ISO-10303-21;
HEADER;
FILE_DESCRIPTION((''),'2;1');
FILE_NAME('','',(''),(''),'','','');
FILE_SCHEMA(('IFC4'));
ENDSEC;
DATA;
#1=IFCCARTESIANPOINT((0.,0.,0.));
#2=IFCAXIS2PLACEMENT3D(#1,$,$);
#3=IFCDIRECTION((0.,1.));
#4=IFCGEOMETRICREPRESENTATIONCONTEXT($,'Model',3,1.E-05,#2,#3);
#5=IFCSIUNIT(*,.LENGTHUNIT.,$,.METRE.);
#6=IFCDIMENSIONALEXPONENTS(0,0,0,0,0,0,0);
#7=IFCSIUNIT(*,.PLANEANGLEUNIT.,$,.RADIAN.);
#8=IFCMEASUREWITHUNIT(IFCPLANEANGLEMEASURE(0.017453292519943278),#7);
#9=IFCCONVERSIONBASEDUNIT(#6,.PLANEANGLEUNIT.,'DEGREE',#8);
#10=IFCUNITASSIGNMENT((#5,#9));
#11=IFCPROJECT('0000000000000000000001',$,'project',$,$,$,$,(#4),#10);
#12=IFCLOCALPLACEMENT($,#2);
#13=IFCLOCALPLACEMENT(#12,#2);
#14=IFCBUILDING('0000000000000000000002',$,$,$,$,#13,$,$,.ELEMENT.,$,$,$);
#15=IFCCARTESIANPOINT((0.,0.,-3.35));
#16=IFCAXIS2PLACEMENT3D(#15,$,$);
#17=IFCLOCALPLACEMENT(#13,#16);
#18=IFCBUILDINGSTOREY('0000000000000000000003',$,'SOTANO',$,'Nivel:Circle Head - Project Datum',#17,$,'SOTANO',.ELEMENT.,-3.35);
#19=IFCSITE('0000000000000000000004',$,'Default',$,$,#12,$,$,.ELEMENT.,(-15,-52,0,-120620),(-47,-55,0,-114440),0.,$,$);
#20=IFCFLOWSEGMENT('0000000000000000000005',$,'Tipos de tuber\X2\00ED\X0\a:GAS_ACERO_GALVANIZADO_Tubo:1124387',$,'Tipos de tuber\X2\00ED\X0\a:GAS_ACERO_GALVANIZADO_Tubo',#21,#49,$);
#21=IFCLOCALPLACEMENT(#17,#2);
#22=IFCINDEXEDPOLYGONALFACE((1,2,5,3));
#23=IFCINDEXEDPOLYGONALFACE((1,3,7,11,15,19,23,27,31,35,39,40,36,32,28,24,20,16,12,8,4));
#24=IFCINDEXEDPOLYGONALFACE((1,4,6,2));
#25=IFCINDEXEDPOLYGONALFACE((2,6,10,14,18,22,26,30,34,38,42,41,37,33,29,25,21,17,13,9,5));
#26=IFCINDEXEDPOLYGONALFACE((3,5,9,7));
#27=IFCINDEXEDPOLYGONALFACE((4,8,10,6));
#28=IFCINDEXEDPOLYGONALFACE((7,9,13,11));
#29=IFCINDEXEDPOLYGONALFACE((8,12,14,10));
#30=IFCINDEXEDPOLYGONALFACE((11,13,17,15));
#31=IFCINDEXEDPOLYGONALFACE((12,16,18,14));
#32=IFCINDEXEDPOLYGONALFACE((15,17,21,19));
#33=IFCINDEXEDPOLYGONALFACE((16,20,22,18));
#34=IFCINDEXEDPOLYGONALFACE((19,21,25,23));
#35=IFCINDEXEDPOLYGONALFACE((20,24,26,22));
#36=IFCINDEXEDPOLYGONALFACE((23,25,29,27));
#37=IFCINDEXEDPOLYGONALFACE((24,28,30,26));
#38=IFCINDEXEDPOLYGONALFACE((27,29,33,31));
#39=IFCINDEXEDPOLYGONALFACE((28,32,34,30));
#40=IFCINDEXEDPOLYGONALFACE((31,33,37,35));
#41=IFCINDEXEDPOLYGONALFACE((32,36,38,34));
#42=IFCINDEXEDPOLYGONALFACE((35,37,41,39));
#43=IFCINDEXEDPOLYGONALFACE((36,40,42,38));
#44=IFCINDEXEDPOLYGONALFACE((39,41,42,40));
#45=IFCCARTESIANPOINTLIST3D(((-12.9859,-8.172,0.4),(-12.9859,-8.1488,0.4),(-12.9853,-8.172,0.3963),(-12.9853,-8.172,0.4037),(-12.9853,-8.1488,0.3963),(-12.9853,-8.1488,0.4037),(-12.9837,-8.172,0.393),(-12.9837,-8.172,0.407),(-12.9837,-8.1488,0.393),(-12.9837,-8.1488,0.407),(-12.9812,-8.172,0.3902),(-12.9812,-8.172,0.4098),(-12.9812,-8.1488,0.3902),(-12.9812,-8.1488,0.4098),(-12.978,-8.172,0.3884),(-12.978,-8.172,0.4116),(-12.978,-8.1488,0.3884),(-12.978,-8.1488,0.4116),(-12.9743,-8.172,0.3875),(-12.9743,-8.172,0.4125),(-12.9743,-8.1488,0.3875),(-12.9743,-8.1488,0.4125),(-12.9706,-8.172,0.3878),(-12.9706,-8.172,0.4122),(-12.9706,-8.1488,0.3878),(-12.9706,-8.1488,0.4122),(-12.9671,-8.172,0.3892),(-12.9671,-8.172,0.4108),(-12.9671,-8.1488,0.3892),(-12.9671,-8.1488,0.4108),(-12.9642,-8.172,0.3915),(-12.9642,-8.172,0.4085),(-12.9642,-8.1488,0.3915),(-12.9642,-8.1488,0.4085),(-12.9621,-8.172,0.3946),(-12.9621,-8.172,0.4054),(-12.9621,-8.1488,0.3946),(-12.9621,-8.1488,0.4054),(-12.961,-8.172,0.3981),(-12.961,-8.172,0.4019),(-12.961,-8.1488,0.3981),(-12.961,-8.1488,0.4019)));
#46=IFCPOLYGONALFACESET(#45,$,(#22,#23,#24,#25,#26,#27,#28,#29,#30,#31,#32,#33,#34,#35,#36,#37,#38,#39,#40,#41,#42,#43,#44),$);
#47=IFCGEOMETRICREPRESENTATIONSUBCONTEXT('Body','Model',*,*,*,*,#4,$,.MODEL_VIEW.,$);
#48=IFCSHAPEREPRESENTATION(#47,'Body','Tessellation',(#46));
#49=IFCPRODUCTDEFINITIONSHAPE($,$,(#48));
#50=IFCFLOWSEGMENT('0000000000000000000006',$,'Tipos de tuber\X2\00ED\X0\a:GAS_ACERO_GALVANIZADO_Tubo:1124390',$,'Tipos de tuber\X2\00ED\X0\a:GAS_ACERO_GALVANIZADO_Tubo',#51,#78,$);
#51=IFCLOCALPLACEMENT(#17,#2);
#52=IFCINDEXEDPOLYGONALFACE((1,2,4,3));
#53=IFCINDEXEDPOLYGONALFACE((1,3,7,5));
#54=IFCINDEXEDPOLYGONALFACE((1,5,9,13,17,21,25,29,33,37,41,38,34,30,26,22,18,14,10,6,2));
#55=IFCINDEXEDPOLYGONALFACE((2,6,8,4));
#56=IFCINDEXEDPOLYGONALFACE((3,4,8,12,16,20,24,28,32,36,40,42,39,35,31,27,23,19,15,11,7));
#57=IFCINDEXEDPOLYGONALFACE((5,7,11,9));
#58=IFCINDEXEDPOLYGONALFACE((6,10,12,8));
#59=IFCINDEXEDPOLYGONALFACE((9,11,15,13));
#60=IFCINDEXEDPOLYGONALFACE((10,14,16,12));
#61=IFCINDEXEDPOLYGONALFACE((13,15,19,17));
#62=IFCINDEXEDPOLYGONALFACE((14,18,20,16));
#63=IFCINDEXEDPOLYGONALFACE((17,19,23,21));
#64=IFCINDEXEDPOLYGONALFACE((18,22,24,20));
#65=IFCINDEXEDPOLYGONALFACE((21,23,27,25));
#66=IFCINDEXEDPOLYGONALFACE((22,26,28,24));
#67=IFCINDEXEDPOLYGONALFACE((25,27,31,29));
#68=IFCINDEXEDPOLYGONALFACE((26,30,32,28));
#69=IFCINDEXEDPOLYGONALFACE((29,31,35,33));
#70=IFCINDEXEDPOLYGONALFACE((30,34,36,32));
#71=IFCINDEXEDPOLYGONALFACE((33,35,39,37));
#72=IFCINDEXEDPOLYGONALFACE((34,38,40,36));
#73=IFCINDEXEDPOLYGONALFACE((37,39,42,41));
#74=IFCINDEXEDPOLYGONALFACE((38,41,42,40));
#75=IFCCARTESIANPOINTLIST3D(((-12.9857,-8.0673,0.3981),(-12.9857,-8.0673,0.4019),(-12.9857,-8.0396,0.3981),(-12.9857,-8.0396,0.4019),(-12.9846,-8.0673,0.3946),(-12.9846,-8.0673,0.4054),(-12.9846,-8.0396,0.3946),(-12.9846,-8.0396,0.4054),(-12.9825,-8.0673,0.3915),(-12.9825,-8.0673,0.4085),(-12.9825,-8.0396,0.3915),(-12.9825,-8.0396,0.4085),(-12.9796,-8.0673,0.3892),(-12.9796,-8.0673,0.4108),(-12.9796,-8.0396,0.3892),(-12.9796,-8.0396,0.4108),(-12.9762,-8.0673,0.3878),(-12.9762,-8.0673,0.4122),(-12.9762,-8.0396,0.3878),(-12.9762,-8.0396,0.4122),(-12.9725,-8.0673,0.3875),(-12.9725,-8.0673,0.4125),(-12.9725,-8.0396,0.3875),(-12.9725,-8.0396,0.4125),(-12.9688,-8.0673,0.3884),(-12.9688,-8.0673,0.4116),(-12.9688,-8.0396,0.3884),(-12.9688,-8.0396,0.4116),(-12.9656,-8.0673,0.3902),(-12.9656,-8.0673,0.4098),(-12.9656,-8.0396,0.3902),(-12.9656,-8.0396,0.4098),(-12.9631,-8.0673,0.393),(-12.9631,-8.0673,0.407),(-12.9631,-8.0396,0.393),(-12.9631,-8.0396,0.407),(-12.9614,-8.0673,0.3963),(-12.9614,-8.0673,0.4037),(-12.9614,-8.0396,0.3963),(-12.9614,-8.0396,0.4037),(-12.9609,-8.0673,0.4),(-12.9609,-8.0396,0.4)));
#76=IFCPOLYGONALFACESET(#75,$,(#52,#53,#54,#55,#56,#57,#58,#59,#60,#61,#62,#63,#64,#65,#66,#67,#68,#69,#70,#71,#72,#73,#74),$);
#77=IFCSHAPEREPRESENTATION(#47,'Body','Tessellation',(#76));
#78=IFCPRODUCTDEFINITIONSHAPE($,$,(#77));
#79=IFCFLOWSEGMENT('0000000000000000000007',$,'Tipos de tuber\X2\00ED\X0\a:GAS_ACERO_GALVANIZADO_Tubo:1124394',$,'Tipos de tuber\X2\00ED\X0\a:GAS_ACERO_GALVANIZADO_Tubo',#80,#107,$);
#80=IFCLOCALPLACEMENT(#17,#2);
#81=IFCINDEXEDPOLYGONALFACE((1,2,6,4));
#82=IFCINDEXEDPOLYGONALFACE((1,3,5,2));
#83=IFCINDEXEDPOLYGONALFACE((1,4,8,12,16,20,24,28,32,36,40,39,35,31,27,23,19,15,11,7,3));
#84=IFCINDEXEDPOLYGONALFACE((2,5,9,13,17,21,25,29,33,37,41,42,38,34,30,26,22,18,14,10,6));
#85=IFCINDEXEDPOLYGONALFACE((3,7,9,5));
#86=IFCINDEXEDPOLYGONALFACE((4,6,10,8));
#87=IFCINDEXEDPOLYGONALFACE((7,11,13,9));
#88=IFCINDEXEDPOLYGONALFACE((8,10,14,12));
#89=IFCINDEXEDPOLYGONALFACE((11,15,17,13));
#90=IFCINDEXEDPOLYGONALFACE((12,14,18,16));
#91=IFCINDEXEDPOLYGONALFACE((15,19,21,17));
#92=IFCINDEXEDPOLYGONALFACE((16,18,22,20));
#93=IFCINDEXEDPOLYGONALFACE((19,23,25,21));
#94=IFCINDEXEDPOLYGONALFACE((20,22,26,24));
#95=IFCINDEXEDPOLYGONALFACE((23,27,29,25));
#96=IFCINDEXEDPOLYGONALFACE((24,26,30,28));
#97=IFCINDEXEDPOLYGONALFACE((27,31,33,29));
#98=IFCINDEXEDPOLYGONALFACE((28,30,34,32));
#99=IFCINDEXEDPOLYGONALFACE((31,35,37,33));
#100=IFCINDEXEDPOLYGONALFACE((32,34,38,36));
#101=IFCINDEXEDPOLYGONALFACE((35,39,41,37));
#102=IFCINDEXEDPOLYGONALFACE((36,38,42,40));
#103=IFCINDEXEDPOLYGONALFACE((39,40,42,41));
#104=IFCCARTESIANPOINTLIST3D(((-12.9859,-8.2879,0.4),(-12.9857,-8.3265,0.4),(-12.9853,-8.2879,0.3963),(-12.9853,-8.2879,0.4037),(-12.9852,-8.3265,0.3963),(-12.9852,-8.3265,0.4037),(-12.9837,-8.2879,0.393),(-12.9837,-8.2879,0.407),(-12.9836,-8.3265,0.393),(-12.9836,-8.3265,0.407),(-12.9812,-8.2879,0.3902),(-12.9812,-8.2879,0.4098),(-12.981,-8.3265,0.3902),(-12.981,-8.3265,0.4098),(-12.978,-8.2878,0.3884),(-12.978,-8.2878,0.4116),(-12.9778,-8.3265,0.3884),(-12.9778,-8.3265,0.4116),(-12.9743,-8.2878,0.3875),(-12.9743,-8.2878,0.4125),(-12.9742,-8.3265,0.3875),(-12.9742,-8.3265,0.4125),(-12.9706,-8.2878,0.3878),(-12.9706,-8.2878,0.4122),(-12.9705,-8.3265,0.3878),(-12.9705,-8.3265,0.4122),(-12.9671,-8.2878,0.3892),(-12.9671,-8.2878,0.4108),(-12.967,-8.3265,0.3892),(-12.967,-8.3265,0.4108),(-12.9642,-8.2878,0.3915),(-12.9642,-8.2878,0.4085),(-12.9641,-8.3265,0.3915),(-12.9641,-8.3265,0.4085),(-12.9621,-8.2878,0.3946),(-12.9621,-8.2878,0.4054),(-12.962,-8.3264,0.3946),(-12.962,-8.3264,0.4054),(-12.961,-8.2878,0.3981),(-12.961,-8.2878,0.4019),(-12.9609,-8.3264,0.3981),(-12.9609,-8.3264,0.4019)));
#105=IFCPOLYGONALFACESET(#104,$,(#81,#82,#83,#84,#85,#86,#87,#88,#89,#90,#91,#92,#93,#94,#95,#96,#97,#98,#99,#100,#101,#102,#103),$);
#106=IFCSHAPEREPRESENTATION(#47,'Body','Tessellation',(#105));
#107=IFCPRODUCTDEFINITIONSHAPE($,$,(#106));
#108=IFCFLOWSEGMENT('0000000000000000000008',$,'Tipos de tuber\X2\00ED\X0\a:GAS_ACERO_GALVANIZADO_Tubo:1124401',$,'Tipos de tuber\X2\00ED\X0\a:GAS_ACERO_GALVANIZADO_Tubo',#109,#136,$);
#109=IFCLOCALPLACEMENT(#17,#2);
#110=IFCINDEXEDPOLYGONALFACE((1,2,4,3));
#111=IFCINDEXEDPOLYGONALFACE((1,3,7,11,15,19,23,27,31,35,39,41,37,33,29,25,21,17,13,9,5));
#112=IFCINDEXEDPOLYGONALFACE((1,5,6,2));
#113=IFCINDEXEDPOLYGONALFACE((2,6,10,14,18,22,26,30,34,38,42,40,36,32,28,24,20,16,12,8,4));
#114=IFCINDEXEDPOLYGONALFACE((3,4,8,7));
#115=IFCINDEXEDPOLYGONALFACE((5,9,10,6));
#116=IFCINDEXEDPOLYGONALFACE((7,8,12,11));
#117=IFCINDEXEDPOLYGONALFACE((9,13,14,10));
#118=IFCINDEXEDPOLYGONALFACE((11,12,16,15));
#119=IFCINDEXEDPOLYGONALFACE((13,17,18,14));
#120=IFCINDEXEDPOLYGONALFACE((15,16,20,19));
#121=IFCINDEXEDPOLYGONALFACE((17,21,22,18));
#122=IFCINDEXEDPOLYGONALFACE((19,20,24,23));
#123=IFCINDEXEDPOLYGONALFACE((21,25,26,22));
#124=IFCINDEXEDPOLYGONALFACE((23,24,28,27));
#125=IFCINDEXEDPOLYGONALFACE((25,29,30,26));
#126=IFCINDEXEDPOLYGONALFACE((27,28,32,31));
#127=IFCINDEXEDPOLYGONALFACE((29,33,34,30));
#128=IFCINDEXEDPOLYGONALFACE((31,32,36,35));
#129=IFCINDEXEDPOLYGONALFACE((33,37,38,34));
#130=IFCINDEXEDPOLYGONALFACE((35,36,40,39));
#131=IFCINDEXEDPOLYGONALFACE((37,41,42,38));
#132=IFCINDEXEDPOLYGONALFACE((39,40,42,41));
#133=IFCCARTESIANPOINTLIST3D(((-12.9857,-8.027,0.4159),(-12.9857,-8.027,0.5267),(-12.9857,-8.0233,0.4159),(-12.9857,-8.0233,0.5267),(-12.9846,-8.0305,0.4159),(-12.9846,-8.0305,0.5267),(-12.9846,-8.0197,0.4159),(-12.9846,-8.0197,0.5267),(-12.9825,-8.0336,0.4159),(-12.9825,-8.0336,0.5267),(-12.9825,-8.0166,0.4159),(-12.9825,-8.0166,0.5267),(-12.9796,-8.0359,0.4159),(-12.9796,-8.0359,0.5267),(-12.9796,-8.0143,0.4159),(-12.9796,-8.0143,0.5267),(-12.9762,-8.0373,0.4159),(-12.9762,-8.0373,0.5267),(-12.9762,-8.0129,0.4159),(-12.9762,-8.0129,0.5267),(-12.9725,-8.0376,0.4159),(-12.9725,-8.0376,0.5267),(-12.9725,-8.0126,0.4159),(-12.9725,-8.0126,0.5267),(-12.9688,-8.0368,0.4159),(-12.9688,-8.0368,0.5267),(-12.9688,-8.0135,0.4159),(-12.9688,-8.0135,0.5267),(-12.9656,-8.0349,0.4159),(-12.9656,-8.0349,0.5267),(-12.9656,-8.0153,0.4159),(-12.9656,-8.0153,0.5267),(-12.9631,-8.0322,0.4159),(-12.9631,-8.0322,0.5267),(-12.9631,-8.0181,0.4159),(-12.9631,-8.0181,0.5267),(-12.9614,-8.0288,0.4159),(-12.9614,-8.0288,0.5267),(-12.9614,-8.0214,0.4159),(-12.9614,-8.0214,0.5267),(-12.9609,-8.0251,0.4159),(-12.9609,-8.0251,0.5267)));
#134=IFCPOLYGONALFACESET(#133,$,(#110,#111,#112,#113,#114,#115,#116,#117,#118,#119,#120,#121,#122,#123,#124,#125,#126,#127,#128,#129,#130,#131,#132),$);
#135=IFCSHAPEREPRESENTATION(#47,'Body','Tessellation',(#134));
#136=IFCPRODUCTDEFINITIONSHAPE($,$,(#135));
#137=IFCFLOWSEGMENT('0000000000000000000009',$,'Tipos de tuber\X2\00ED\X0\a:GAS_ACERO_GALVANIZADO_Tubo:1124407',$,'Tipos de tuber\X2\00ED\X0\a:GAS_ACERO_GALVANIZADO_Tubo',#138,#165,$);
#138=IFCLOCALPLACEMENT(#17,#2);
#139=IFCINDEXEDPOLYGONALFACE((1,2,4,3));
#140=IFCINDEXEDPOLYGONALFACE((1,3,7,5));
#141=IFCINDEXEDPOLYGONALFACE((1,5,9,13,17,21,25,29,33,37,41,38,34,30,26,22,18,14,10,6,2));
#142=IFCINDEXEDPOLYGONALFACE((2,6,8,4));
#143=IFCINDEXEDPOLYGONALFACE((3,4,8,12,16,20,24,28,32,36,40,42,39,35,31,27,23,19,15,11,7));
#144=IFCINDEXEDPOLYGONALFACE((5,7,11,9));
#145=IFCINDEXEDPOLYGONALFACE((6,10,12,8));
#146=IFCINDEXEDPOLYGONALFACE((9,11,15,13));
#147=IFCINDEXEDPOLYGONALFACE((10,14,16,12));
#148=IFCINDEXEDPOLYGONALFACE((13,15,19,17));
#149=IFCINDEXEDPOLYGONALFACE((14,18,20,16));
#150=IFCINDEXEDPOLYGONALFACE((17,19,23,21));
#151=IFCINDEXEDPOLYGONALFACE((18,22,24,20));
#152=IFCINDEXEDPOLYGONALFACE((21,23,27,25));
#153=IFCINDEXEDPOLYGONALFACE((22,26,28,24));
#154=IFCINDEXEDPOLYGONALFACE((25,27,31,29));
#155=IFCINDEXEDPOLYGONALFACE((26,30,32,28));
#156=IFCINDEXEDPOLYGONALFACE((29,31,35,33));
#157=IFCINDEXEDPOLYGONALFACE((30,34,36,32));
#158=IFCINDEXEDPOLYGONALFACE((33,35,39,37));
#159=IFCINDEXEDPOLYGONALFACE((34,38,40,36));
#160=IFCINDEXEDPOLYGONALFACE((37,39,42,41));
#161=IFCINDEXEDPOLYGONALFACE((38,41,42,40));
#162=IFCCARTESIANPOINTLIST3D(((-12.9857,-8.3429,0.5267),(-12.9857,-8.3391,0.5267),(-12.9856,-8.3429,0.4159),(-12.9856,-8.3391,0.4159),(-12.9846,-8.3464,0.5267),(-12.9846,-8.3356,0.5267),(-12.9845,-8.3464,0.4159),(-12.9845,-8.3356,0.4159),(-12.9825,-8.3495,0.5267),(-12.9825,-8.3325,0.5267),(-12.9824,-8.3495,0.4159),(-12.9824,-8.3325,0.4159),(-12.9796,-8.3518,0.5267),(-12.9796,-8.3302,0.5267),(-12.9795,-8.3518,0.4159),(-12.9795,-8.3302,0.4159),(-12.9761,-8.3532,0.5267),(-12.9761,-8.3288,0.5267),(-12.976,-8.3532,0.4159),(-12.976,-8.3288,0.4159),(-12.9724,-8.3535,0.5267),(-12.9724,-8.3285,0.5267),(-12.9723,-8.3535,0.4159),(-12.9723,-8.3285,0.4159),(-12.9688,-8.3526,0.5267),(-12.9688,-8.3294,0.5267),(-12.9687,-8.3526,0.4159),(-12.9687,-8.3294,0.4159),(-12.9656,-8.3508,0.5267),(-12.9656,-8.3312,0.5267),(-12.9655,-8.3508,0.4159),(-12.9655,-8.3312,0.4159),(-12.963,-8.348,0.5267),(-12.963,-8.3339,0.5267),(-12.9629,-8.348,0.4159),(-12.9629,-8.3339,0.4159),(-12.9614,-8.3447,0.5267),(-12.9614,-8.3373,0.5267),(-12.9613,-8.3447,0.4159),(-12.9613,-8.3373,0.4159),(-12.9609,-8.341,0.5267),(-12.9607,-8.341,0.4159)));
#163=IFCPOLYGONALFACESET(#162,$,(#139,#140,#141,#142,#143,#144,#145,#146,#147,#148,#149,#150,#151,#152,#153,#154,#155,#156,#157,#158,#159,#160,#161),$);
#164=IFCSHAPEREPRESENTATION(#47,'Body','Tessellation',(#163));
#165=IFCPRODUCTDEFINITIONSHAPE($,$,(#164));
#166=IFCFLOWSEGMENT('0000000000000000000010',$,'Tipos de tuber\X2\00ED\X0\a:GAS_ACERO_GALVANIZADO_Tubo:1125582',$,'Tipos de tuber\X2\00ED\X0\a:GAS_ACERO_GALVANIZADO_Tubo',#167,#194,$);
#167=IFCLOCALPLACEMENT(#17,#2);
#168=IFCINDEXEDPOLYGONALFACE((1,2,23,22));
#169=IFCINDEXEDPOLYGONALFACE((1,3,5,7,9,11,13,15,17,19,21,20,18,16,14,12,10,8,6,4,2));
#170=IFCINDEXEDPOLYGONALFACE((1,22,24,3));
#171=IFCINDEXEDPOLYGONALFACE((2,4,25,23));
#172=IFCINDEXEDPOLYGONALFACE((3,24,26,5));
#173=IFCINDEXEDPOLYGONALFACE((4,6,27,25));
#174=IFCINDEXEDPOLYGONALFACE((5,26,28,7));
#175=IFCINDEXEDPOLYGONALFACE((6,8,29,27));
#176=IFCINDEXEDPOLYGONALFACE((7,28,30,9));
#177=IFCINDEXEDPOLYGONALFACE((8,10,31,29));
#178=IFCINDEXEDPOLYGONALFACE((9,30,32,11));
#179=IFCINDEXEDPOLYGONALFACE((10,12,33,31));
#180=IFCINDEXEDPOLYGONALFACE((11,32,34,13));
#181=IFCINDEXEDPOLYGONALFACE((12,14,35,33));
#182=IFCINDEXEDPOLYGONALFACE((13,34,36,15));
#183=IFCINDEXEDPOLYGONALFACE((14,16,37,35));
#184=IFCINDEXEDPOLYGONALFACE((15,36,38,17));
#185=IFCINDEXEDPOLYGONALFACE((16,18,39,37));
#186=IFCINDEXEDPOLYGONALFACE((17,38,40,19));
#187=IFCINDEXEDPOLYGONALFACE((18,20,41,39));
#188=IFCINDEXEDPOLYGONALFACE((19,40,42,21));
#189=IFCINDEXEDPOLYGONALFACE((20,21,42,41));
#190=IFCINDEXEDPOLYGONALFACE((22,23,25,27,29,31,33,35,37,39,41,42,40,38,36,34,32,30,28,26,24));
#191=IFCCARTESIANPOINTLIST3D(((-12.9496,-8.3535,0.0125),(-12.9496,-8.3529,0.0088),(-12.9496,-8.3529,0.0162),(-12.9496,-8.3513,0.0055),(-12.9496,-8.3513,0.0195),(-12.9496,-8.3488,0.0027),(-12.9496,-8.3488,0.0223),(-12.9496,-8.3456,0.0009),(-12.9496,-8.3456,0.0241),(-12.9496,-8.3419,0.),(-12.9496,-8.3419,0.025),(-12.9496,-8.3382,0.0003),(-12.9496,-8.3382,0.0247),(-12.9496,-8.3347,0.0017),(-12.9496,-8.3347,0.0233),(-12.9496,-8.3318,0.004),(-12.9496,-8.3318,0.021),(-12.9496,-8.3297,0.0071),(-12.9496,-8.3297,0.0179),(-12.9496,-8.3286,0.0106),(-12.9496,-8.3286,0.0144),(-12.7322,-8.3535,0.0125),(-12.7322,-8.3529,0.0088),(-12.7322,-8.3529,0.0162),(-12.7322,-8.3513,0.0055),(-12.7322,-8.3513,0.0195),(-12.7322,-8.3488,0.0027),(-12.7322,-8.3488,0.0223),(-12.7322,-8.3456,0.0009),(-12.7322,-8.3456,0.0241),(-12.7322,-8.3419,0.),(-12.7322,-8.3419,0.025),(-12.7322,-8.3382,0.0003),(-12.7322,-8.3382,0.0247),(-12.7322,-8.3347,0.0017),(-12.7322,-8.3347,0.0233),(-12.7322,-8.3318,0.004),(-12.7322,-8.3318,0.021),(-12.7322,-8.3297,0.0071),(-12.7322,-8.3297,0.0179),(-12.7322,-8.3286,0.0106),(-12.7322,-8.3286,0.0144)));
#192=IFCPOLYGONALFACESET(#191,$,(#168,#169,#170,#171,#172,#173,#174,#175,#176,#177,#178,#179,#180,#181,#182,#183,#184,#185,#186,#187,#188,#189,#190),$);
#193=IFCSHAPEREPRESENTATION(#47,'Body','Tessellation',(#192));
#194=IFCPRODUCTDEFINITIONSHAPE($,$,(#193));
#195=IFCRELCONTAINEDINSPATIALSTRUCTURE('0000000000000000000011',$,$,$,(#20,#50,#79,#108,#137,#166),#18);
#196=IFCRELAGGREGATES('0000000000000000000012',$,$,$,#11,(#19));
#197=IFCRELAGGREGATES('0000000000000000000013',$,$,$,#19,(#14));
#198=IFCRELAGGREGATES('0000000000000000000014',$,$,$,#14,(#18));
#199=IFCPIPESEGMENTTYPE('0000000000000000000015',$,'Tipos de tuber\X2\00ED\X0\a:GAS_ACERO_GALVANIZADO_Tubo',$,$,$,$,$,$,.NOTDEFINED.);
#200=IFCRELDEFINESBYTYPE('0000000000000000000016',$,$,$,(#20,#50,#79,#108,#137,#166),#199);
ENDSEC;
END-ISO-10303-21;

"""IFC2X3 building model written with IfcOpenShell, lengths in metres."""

from ifc_helpers import new_model, entity, si_unit, converted_unit, direction, frame, frame_2d, origin, origin_2d_with_axis, place, context, subcontext, project, spatial, circle, extrude, type_object, element, save


model = new_model("IFC2X3")

# Units and contexts
model_context = context("Model", 3, precision=1e-05, world=origin(), true_north=direction((0.0, 1.0)))
body_context = subcontext(model_context, "Body", "Model", "MODEL_VIEW")
ifc_project = project(units=[si_unit("LENGTHUNIT", "METRE"), converted_unit("PLANEANGLEUNIT", "DEGREE", entity("IfcPlaneAngleMeasure", 0.017453292519943278), si_unit("PLANEANGLEUNIT", "RADIAN"), dimensions=[0, 0, 0, 0, 0, 0, 0])], contexts=[model_context])

# Site, building, storey
site_placement = place(None, origin())
site = spatial("IfcSite", under=ifc_project, at=site_placement, Name="Default", CompositionType="ELEMENT", RefLatitude=(-15, -52, 0, -120620), RefLongitude=(-47, -55, 0, -114440), RefElevation=0.0)
building_placement = place(site_placement, origin())
building = spatial("IfcBuilding", under=site, at=building_placement, CompositionType="ELEMENT")
storey_placement = place(building_placement, frame((0.0, 0.0, -3.35)))
storey = spatial("IfcBuildingStorey", under=building, at=storey_placement, Name="SOTANO", ObjectType="Nivel:Circle Head - Project Datum", LongName="SOTANO", CompositionType="ELEMENT", Elevation=-3.35)

# Flow segments
pipe_segment_type_1 = type_object("IfcPipeSegmentType", Name="Tipos de tubería:GAS_ACERO_GALVANIZADO_Tubo", PredefinedType="NOTDEFINED")
flow_segment_1_placement = place(storey_placement, origin())
element("IfcFlowSegment", 1, at=flow_segment_1_placement, inside=storey, type_object=pipe_segment_type_1, Name="Tipos de tubería:GAS_ACERO_GALVANIZADO_Tubo:1124387", ObjectType="Tipos de tubería:GAS_ACERO_GALVANIZADO_Tubo", context=body_context, shape_type="SweptSolid", body=[
    extrude(circle(Radius=0.0125, at=origin_2d_with_axis()), frame((-12.9734, -8.172, 0.4), z_axis=(0.0, 1.0, 0.0), x_axis=(-1.0, 0.0, 0.0)), (0.0, 0.0, 1.0), 0.0232),
])
flow_segment_2_placement = place(storey_placement, origin())
element("IfcFlowSegment", 2, at=flow_segment_2_placement, inside=storey, type_object=pipe_segment_type_1, Name="Tipos de tubería:GAS_ACERO_GALVANIZADO_Tubo:1124390", ObjectType="Tipos de tubería:GAS_ACERO_GALVANIZADO_Tubo", context=body_context, shape_type="SweptSolid", body=[
    extrude(circle(Radius=0.0125, at=origin_2d_with_axis()), frame((-12.9734, -8.0673, 0.4), z_axis=(0.0, 1.0, 0.0), x_axis=(1.0, 0.0, 0.0)), (0.0, 0.0, 1.0), 0.0276),
])
flow_segment_3_placement = place(storey_placement, origin())
element("IfcFlowSegment", 3, at=flow_segment_3_placement, inside=storey, type_object=pipe_segment_type_1, Name="Tipos de tubería:GAS_ACERO_GALVANIZADO_Tubo:1124394", ObjectType="Tipos de tubería:GAS_ACERO_GALVANIZADO_Tubo", context=body_context, shape_type="SweptSolid", body=[
    extrude(circle(Radius=0.0125, at=origin_2d_with_axis()), frame((-12.9734, -8.2878, 0.4), z_axis=(0.003886, -0.999992, 0.0), x_axis=(-0.999992, -0.003886, 0.0)), (0.0, 0.0, 1.0), 0.0387),
])
flow_segment_4_placement = place(storey_placement, origin())
element("IfcFlowSegment", 4, at=flow_segment_4_placement, inside=storey, type_object=pipe_segment_type_1, Name="Tipos de tubería:GAS_ACERO_GALVANIZADO_Tubo:1124401", ObjectType="Tipos de tubería:GAS_ACERO_GALVANIZADO_Tubo", context=body_context, shape_type="SweptSolid", body=[
    extrude(circle(Radius=0.0125, at=frame_2d((0.0, 0.0), x_axis=(1.0, 0.0))), frame((-12.9734, -8.0251, 0.4159)), (0.0, 0.0, 1.0), 0.1108),
])
flow_segment_5_placement = place(storey_placement, origin())
element("IfcFlowSegment", 5, at=flow_segment_5_placement, inside=storey, type_object=pipe_segment_type_1, Name="Tipos de tubería:GAS_ACERO_GALVANIZADO_Tubo:1124407", ObjectType="Tipos de tubería:GAS_ACERO_GALVANIZADO_Tubo", context=body_context, shape_type="SweptSolid", body=[
    extrude(circle(Radius=0.0125, at=frame_2d((0.0, 0.0), x_axis=(1.0, 0.0))), frame((-12.9732, -8.341, 0.4159), z_axis=(-0.000954, 0.0, 1.0), x_axis=(1.0, 0.0, 0.000954)), (0.0, 0.0, 1.0), 0.1108),
])
flow_segment_6_placement = place(storey_placement, origin())
element("IfcFlowSegment", 6, at=flow_segment_6_placement, inside=storey, type_object=pipe_segment_type_1, Name="Tipos de tubería:GAS_ACERO_GALVANIZADO_Tubo:1125582", ObjectType="Tipos de tubería:GAS_ACERO_GALVANIZADO_Tubo", context=body_context, shape_type="SweptSolid", body=[
    extrude(circle(Radius=0.0125, at=origin_2d_with_axis()), frame((-12.9496, -8.341, 0.0125), z_axis=(1.0, 0.0, 0.0), x_axis=(0.0, -1.0, 0.0)), (0.0, 0.0, 1.0), 0.2173),
])

save(model, "model.ifc")
